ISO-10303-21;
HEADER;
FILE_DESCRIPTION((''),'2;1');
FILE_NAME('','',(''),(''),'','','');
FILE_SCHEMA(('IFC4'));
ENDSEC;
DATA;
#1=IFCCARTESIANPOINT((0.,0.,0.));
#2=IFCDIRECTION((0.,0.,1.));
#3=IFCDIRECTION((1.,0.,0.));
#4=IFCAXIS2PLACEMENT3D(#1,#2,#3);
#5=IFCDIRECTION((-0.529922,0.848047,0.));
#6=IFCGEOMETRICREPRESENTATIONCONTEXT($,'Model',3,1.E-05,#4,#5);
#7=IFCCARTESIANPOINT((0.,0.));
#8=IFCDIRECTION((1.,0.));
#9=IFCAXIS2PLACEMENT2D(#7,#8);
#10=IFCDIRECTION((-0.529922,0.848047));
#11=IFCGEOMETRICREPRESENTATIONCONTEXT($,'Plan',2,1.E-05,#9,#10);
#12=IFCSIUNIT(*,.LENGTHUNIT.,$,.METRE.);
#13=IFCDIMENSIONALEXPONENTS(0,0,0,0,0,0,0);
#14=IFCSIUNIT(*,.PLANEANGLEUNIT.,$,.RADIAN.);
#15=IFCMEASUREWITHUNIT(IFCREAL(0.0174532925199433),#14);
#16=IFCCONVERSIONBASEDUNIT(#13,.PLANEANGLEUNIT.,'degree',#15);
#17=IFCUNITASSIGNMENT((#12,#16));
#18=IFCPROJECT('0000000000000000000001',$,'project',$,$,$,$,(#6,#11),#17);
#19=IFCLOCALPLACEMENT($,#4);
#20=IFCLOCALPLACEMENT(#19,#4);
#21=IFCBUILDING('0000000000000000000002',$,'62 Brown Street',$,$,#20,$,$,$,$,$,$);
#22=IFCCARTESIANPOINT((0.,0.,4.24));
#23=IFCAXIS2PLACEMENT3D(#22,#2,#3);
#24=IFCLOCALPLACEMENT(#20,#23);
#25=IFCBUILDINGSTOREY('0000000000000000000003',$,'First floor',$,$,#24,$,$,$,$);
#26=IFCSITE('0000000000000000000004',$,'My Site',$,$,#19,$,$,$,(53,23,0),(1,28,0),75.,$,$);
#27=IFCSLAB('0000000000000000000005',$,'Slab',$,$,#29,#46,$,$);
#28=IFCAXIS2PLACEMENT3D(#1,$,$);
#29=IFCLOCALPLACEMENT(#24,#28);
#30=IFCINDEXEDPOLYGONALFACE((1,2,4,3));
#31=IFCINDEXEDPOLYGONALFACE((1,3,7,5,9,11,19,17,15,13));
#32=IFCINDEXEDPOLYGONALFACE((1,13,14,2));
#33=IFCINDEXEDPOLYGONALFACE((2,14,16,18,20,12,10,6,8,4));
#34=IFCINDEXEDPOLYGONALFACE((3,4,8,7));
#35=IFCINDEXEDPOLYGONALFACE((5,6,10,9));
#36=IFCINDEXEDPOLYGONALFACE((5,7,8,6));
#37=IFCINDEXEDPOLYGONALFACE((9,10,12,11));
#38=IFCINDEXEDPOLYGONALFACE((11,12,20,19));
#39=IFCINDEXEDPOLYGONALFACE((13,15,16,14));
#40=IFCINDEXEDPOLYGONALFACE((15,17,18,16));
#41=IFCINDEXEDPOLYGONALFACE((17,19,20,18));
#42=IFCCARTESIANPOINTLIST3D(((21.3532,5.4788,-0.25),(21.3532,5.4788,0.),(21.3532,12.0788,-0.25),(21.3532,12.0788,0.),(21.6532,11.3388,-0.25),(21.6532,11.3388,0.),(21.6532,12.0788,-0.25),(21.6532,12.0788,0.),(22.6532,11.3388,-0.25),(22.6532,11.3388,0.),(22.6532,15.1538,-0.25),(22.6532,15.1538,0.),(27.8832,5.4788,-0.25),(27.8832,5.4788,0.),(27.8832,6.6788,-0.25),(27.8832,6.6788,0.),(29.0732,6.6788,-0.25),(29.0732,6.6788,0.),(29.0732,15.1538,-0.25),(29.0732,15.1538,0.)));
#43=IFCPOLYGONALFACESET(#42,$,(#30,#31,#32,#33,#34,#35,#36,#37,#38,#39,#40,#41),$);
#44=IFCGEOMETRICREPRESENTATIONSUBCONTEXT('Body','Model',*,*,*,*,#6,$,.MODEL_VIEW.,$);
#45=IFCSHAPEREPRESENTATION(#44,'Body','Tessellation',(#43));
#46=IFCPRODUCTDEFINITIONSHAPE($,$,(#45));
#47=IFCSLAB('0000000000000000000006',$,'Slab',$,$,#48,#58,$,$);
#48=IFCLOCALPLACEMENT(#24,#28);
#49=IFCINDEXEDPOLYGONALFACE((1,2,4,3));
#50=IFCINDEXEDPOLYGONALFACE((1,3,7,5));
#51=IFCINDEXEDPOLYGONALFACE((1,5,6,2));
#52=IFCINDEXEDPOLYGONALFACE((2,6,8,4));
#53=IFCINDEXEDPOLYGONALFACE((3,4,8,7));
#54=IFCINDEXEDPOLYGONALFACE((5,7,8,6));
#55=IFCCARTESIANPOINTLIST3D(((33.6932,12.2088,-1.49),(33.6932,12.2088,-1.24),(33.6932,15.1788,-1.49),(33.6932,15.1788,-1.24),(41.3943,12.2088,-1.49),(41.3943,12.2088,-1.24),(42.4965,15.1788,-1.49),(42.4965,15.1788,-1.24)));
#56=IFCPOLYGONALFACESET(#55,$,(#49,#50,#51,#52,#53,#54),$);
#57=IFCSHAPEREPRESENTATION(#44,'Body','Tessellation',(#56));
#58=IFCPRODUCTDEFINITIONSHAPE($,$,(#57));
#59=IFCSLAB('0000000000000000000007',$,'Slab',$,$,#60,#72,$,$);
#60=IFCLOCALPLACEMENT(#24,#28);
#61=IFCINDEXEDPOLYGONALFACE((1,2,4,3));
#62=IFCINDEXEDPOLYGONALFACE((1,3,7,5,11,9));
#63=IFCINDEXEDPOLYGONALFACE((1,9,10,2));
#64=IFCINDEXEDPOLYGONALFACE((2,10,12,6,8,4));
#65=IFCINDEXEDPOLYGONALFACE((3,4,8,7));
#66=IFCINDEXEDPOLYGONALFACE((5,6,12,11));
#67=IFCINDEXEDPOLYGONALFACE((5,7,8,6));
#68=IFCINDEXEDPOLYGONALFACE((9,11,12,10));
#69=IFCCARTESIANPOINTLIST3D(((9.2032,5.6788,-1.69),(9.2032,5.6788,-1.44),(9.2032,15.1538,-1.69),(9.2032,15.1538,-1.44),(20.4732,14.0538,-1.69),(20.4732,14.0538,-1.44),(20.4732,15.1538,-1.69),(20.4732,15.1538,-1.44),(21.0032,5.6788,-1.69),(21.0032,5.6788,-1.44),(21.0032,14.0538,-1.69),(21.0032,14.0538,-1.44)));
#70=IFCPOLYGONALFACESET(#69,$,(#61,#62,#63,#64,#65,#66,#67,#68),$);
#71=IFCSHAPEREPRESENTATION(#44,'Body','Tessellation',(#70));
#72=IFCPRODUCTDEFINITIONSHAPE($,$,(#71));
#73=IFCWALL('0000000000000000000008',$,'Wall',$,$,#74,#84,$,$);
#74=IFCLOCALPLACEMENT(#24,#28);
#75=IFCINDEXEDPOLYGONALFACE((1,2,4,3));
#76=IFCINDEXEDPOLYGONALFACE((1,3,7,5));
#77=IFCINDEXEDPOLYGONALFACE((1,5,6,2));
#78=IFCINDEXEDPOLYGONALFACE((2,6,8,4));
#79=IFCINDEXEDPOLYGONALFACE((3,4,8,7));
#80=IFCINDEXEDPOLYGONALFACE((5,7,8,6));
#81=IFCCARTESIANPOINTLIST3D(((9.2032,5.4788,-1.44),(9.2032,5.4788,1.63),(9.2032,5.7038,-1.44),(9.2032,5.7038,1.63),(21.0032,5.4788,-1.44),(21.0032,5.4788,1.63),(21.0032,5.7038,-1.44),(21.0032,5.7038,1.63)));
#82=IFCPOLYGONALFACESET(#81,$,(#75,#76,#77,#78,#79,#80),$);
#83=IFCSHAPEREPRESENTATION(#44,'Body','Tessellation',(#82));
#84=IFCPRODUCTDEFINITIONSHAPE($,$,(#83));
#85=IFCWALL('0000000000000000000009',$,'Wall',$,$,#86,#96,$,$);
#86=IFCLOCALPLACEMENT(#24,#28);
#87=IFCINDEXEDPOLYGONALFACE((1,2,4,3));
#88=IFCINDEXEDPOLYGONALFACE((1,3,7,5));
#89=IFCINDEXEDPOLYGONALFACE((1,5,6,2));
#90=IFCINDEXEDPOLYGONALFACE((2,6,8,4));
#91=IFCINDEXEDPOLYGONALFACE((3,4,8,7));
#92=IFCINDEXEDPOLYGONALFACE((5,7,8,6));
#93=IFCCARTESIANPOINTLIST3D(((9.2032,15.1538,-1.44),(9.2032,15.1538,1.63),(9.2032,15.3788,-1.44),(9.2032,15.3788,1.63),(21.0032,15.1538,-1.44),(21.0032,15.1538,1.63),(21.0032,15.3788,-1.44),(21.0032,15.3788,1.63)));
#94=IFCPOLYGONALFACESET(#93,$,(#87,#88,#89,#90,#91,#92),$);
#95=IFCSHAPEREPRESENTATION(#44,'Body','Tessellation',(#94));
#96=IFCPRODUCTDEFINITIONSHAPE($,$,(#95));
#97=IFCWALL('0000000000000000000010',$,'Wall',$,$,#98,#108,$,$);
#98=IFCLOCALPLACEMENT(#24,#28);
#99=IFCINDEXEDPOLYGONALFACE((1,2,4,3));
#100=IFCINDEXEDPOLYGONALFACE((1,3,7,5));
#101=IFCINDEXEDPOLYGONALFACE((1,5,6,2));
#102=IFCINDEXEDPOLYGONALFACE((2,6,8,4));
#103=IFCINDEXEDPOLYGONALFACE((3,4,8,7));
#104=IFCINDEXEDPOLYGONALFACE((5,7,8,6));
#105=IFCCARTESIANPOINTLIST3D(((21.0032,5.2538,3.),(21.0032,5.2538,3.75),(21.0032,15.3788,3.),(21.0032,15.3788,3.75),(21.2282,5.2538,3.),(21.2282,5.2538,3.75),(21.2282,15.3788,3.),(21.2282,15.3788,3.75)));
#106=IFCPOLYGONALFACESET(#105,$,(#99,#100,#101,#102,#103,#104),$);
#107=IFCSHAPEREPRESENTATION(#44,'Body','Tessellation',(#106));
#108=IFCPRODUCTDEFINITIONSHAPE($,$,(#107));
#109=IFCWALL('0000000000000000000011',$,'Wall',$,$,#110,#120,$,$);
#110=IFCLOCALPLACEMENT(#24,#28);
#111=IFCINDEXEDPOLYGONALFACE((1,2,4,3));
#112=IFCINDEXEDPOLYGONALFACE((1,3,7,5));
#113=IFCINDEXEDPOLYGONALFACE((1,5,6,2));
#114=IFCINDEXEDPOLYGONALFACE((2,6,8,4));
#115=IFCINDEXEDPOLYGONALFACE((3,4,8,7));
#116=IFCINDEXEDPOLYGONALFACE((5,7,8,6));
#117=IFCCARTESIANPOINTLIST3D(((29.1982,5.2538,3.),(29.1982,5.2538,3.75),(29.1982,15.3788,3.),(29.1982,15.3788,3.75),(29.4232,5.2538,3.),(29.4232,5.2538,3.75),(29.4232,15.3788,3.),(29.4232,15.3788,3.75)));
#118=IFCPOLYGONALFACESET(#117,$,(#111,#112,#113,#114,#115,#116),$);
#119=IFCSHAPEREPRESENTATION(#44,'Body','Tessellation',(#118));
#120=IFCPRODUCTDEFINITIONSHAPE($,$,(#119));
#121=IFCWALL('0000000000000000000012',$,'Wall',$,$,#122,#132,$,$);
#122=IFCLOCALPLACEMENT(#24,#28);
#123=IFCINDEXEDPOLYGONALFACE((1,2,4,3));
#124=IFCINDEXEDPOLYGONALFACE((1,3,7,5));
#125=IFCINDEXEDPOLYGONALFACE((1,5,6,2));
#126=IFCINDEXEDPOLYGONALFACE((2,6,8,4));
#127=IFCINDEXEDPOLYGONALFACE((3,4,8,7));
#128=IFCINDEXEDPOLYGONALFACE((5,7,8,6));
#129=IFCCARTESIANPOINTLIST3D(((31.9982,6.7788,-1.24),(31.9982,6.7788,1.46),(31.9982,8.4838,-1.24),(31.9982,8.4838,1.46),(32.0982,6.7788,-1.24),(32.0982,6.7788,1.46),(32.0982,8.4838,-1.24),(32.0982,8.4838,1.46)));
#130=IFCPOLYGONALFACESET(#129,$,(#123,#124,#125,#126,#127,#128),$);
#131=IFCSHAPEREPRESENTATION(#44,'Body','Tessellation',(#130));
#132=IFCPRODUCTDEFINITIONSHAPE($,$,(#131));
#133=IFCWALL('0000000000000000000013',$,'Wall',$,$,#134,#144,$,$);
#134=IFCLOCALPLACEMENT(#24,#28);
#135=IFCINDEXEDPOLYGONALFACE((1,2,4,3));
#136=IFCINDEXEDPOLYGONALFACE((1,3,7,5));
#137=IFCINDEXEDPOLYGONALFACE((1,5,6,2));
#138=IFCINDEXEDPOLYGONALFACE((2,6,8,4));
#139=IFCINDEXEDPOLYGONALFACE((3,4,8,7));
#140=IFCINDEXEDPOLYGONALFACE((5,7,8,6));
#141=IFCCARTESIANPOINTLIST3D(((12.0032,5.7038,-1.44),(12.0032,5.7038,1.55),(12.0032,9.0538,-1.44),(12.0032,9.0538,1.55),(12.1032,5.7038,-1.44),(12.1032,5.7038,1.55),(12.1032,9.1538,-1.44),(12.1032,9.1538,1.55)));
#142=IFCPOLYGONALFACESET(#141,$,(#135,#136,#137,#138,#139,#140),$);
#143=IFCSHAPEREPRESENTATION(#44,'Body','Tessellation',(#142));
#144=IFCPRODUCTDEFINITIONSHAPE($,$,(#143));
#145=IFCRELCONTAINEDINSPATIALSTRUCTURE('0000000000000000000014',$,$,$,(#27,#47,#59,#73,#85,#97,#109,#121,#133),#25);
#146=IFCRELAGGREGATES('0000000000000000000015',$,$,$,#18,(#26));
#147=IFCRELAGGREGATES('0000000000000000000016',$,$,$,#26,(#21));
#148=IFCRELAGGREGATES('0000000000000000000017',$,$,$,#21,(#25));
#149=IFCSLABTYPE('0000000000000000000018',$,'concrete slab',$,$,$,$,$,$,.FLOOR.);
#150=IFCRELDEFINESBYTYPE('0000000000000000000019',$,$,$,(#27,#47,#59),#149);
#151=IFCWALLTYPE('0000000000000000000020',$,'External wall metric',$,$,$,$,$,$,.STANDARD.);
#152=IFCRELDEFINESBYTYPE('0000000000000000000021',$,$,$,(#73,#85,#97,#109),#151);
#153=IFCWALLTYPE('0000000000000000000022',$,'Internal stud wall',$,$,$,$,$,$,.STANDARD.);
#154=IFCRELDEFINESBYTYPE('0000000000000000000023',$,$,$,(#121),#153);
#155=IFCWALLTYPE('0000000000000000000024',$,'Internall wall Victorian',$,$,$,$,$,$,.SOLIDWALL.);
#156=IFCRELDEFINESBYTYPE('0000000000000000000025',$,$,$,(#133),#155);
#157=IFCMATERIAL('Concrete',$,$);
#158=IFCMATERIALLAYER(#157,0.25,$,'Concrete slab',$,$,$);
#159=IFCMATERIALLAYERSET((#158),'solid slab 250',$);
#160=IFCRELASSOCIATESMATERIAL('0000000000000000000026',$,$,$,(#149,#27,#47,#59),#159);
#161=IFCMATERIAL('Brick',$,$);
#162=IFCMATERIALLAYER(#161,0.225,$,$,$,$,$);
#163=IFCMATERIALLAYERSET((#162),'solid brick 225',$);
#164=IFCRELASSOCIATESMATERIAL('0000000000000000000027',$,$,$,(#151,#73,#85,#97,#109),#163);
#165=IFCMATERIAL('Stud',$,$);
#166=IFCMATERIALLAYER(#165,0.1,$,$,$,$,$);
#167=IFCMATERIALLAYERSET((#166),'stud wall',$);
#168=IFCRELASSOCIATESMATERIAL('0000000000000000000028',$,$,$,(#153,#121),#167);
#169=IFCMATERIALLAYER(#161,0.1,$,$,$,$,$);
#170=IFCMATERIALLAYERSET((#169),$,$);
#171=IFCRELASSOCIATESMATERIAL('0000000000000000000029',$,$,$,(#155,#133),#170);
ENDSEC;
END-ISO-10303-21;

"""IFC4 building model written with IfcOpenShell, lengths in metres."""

from ifc_helpers import new_model, entity, si_unit, converted_unit, direction, frame, origin_with_axes, origin_2d_with_axis, place, context, subcontext, project, spatial, line, indexed_curve, outline, extrude, clip, halfspace, material, layer, layer_set, layer_usage, type_object, element, save


model = new_model("IFC4")

# Units and contexts
model_context = context("Model", 3, precision=1e-05, world=origin_with_axes(), true_north=direction((-0.529922, 0.848047, 0.0)))
plan_context = context("Plan", 2, precision=1e-05, world=origin_2d_with_axis(), true_north=direction((-0.529922, 0.848047)))
body_context_1 = subcontext(model_context, "Body", "Model", "MODEL_VIEW")
ifc_project = project(units=[si_unit("LENGTHUNIT", "METRE"), converted_unit("PLANEANGLEUNIT", "degree", entity("IfcReal", 0.0174532925199433), si_unit("PLANEANGLEUNIT", "RADIAN"), dimensions=[0, 0, 0, 0, 0, 0, 0])], contexts=[model_context, plan_context])

# Site, building, storey
site_placement = place(None, origin_with_axes())
site = spatial("IfcSite", under=ifc_project, at=site_placement, Name="My Site", RefLatitude=(53, 23, 0), RefLongitude=(1, 28, 0), RefElevation=75.0)
building_placement = place(site_placement, origin_with_axes())
building = spatial("IfcBuilding", under=site, at=building_placement, Name="62 Brown Street")
storey_placement = place(building_placement, frame((0.0, 0.0, 4.24), z_axis=(0.0, 0.0, 1.0), x_axis=(1.0, 0.0, 0.0)))
storey = spatial("IfcBuildingStorey", under=building, at=storey_placement, Name="First floor")

# Shared definitions
ifc_material_1 = material(Name="Concrete")

# Slabs
ifc_layer_1 = layer(ifc_material_1, 0.25, Name="Concrete slab")
ifc_layer_set_1 = layer_set([ifc_layer_1], Name="solid slab 250")
ifc_layer_usage_1 = layer_usage(ifc_layer_set_1, "AXIS3", "POSITIVE", 0.0)
slab_type = type_object("IfcSlabType", Name="concrete slab", PredefinedType="FLOOR", material=ifc_layer_set_1)
slab_1_placement = place(storey_placement, frame((21.3532, 5.4788, -0.25), z_axis=(0.0, 0.0, 1.0), x_axis=(1.0, 0.0, 0.0)))
element("IfcSlab", 1, at=slab_1_placement, inside=storey, type_object=slab_type, material=ifc_layer_usage_1, Name="Slab", context=body_context_1, shape_type="SweptSolid", body=[
    extrude(outline(indexed_curve([(6.53, 1.2), (6.53, 0.0), (0.0, 0.0), (0.0, 6.6), (0.3, 6.6), (0.3, 5.86), (1.3, 5.86), (1.3, 9.675), (7.72, 9.675), (7.72, 1.2), (6.53, 1.2)])), None, (0.0, 0.0, 1.0), 0.25),
])
ifc_layer_usage_2 = layer_usage(ifc_layer_set_1, "AXIS3", "POSITIVE", 0.0)
slab_2_placement = place(storey_placement, frame((33.6932, 12.2088, -1.49), z_axis=(0.0, 0.0, 1.0), x_axis=(1.0, 0.0, 0.0)))
element("IfcSlab", 2, at=slab_2_placement, inside=storey, type_object=slab_type, material=ifc_layer_usage_2, Name="Slab", context=body_context_1, shape_type="SweptSolid", body=[
    extrude(outline(indexed_curve([(8.8033, 2.97), (7.7011, 0.0), (0.0, 0.0), (0.0, 2.97)], segments=[line(4, 1), line(1, 2), line(2, 3), line(3, 4)], self_intersect=False)), None, (0.0, 0.0, 1.0), 0.25),
])
ifc_layer_usage_3 = layer_usage(ifc_layer_set_1, "AXIS3", "POSITIVE", 0.0)
slab_3_placement = place(storey_placement, frame((9.2032, 5.6788, -1.69), z_axis=(0.0, 0.0, 1.0), x_axis=(1.0, 0.0, 0.0)))
element("IfcSlab", 3, at=slab_3_placement, inside=storey, type_object=slab_type, material=ifc_layer_usage_3, Name="Slab", context=body_context_1, shape_type="SweptSolid", body=[
    extrude(outline(indexed_curve([(11.27, 9.475), (11.8, 0.0), (0.0, 0.0), (0.0, 9.475), (11.8, 8.375), (11.27, 8.375)], segments=[line(6, 1), line(1, 4), line(4, 3), line(3, 2), line(2, 5), line(5, 6)], self_intersect=False)), None, (0.0, 0.0, 1.0), 0.25),
])

# Walls
ifc_material_2 = material(Name="Brick")
ifc_layer_2 = layer(ifc_material_2, 0.225)
ifc_layer_set_2 = layer_set([ifc_layer_2], Name="solid brick 225")
ifc_layer_usage_4 = layer_usage(ifc_layer_set_2, "AXIS2", "POSITIVE", 0.0)
wall_type_1 = type_object("IfcWallType", Name="External wall metric", PredefinedType="STANDARD", material=ifc_layer_set_2)
wall_1_placement = place(storey_placement, frame((9.2032, 5.4788, -1.44), z_axis=(0.0, 0.0, 1.0), x_axis=(1.0, 0.0, 0.0)))
element("IfcWall", 4, at=wall_1_placement, inside=storey, type_object=wall_type_1, material=ifc_layer_usage_4, Name="Wall", context=body_context_1, shape_type="SweptSolid", body=[
    extrude(outline(indexed_curve([(0.0, 0.0), (0.0, 0.225), (11.8, 0.225), (11.8, 0.0), (0.0, 0.0)], self_intersect=False)), origin_with_axes(), (0.0, 0.0, 1.0), 3.07),
])
ifc_layer_usage_5 = layer_usage(ifc_layer_set_2, "AXIS2", "POSITIVE", 0.0)
wall_2_placement = place(storey_placement, frame((21.0032, 15.3788, -1.44), z_axis=(0.0, 0.0, 1.0), x_axis=(-1.0, 0.0, 0.0)))
element("IfcWall", 5, at=wall_2_placement, inside=storey, type_object=wall_type_1, material=ifc_layer_usage_5, Name="Wall", context=body_context_1, shape_type="SweptSolid", body=[
    extrude(outline(indexed_curve([(0.0, 0.0), (0.0, 0.225), (11.8, 0.225), (11.8, 0.0), (0.0, 0.0)], self_intersect=False)), origin_with_axes(), (0.0, 0.0, 1.0), 3.07),
])

# Walls
ifc_layer_usage_6 = layer_usage(ifc_layer_set_2, "AXIS2", "POSITIVE", 0.0)
wall_3_placement = place(storey_placement, frame((21.0032, 15.3788, 3.0), z_axis=(0.0, 0.0, 1.0), x_axis=(0.0, -1.0, 0.0)))
element("IfcWall", 6, at=wall_3_placement, inside=storey, type_object=wall_type_1, material=ifc_layer_usage_6, Name="Wall", context=body_context_1, shape_type="SweptSolid", body=[
    extrude(outline(indexed_curve([(0.0, 0.0), (0.0, 0.225), (10.125, 0.225), (10.125, 0.0), (0.0, 0.0)], self_intersect=False)), origin_with_axes(), (0.0, 0.0, 1.0), 0.75),
])
ifc_layer_usage_7 = layer_usage(ifc_layer_set_2, "AXIS2", "POSITIVE", 0.0)
wall_4_placement = place(storey_placement, frame((29.4232, 5.2538, 3.0), z_axis=(0.0, 0.0, 1.0), x_axis=(0.0, 1.0, 0.0)))
element("IfcWall", 7, at=wall_4_placement, inside=storey, type_object=wall_type_1, material=ifc_layer_usage_7, Name="Wall", context=body_context_1, shape_type="SweptSolid", body=[
    extrude(outline(indexed_curve([(0.0, 0.0), (0.0, 0.225), (10.125, 0.225), (10.125, 0.0), (0.0, 0.0)], self_intersect=False)), origin_with_axes(), (0.0, 0.0, 1.0), 0.75),
])
ifc_material_3 = material(Name="Stud")
ifc_layer_3 = layer(ifc_material_3, 0.1)
ifc_layer_set_3 = layer_set([ifc_layer_3], Name="stud wall")
ifc_layer_usage_8 = layer_usage(ifc_layer_set_3, "AXIS2", "POSITIVE", 0.0)
wall_type_2 = type_object("IfcWallType", Name="Internal stud wall", PredefinedType="STANDARD", material=ifc_layer_set_3)
wall_5_placement = place(storey_placement, frame((32.0982, 6.7788, -1.24), z_axis=(0.0, 0.0, 1.0), x_axis=(0.000001, 1.0, 0.0)))
element("IfcWall", 8, at=wall_5_placement, inside=storey, type_object=wall_type_2, material=ifc_layer_usage_8, Name="Wall", context=body_context_1, shape_type="SweptSolid", body=[
    extrude(outline(indexed_curve([(0.0, 0.0), (0.0, 0.1), (1.705, 0.1), (1.705, 0.0), (0.0, 0.0)], self_intersect=False)), origin_with_axes(), (0.0, 0.0, 1.0), 2.7),
])
ifc_layer_4 = layer(ifc_material_2, 0.1)
ifc_layer_set_4 = layer_set([ifc_layer_4])
ifc_layer_usage_9 = layer_usage(ifc_layer_set_4, "AXIS2", "POSITIVE", 0.0)
wall_type_3 = type_object("IfcWallType", Name="Internall wall Victorian", PredefinedType="SOLIDWALL", material=ifc_layer_set_4)
wall_6_placement = place(storey_placement, frame((12.1032, 5.7038, -1.44), z_axis=(0.0, 0.0, 1.0), x_axis=(0.0, 1.0, 0.0)))
element("IfcWall", 9, at=wall_6_placement, inside=storey, type_object=wall_type_3, material=ifc_layer_usage_9, Name="Wall", context=body_context_1, shape_type="Clipping", body=[
    clip(extrude(outline(indexed_curve([(0.0, 0.0), (0.0, 0.1), (3.45, 0.1), (3.45, 0.0), (0.0, 0.0)], self_intersect=False)), origin_with_axes(), (0.0, 0.0, 1.0), 2.99), halfspace(frame((3.45, 0.0, -2.8), z_axis=(0.707107, 0.707107, 0.0), x_axis=(0.707107, -0.707107, 0.0)), False)),
])

save(model, "model.ifc")
